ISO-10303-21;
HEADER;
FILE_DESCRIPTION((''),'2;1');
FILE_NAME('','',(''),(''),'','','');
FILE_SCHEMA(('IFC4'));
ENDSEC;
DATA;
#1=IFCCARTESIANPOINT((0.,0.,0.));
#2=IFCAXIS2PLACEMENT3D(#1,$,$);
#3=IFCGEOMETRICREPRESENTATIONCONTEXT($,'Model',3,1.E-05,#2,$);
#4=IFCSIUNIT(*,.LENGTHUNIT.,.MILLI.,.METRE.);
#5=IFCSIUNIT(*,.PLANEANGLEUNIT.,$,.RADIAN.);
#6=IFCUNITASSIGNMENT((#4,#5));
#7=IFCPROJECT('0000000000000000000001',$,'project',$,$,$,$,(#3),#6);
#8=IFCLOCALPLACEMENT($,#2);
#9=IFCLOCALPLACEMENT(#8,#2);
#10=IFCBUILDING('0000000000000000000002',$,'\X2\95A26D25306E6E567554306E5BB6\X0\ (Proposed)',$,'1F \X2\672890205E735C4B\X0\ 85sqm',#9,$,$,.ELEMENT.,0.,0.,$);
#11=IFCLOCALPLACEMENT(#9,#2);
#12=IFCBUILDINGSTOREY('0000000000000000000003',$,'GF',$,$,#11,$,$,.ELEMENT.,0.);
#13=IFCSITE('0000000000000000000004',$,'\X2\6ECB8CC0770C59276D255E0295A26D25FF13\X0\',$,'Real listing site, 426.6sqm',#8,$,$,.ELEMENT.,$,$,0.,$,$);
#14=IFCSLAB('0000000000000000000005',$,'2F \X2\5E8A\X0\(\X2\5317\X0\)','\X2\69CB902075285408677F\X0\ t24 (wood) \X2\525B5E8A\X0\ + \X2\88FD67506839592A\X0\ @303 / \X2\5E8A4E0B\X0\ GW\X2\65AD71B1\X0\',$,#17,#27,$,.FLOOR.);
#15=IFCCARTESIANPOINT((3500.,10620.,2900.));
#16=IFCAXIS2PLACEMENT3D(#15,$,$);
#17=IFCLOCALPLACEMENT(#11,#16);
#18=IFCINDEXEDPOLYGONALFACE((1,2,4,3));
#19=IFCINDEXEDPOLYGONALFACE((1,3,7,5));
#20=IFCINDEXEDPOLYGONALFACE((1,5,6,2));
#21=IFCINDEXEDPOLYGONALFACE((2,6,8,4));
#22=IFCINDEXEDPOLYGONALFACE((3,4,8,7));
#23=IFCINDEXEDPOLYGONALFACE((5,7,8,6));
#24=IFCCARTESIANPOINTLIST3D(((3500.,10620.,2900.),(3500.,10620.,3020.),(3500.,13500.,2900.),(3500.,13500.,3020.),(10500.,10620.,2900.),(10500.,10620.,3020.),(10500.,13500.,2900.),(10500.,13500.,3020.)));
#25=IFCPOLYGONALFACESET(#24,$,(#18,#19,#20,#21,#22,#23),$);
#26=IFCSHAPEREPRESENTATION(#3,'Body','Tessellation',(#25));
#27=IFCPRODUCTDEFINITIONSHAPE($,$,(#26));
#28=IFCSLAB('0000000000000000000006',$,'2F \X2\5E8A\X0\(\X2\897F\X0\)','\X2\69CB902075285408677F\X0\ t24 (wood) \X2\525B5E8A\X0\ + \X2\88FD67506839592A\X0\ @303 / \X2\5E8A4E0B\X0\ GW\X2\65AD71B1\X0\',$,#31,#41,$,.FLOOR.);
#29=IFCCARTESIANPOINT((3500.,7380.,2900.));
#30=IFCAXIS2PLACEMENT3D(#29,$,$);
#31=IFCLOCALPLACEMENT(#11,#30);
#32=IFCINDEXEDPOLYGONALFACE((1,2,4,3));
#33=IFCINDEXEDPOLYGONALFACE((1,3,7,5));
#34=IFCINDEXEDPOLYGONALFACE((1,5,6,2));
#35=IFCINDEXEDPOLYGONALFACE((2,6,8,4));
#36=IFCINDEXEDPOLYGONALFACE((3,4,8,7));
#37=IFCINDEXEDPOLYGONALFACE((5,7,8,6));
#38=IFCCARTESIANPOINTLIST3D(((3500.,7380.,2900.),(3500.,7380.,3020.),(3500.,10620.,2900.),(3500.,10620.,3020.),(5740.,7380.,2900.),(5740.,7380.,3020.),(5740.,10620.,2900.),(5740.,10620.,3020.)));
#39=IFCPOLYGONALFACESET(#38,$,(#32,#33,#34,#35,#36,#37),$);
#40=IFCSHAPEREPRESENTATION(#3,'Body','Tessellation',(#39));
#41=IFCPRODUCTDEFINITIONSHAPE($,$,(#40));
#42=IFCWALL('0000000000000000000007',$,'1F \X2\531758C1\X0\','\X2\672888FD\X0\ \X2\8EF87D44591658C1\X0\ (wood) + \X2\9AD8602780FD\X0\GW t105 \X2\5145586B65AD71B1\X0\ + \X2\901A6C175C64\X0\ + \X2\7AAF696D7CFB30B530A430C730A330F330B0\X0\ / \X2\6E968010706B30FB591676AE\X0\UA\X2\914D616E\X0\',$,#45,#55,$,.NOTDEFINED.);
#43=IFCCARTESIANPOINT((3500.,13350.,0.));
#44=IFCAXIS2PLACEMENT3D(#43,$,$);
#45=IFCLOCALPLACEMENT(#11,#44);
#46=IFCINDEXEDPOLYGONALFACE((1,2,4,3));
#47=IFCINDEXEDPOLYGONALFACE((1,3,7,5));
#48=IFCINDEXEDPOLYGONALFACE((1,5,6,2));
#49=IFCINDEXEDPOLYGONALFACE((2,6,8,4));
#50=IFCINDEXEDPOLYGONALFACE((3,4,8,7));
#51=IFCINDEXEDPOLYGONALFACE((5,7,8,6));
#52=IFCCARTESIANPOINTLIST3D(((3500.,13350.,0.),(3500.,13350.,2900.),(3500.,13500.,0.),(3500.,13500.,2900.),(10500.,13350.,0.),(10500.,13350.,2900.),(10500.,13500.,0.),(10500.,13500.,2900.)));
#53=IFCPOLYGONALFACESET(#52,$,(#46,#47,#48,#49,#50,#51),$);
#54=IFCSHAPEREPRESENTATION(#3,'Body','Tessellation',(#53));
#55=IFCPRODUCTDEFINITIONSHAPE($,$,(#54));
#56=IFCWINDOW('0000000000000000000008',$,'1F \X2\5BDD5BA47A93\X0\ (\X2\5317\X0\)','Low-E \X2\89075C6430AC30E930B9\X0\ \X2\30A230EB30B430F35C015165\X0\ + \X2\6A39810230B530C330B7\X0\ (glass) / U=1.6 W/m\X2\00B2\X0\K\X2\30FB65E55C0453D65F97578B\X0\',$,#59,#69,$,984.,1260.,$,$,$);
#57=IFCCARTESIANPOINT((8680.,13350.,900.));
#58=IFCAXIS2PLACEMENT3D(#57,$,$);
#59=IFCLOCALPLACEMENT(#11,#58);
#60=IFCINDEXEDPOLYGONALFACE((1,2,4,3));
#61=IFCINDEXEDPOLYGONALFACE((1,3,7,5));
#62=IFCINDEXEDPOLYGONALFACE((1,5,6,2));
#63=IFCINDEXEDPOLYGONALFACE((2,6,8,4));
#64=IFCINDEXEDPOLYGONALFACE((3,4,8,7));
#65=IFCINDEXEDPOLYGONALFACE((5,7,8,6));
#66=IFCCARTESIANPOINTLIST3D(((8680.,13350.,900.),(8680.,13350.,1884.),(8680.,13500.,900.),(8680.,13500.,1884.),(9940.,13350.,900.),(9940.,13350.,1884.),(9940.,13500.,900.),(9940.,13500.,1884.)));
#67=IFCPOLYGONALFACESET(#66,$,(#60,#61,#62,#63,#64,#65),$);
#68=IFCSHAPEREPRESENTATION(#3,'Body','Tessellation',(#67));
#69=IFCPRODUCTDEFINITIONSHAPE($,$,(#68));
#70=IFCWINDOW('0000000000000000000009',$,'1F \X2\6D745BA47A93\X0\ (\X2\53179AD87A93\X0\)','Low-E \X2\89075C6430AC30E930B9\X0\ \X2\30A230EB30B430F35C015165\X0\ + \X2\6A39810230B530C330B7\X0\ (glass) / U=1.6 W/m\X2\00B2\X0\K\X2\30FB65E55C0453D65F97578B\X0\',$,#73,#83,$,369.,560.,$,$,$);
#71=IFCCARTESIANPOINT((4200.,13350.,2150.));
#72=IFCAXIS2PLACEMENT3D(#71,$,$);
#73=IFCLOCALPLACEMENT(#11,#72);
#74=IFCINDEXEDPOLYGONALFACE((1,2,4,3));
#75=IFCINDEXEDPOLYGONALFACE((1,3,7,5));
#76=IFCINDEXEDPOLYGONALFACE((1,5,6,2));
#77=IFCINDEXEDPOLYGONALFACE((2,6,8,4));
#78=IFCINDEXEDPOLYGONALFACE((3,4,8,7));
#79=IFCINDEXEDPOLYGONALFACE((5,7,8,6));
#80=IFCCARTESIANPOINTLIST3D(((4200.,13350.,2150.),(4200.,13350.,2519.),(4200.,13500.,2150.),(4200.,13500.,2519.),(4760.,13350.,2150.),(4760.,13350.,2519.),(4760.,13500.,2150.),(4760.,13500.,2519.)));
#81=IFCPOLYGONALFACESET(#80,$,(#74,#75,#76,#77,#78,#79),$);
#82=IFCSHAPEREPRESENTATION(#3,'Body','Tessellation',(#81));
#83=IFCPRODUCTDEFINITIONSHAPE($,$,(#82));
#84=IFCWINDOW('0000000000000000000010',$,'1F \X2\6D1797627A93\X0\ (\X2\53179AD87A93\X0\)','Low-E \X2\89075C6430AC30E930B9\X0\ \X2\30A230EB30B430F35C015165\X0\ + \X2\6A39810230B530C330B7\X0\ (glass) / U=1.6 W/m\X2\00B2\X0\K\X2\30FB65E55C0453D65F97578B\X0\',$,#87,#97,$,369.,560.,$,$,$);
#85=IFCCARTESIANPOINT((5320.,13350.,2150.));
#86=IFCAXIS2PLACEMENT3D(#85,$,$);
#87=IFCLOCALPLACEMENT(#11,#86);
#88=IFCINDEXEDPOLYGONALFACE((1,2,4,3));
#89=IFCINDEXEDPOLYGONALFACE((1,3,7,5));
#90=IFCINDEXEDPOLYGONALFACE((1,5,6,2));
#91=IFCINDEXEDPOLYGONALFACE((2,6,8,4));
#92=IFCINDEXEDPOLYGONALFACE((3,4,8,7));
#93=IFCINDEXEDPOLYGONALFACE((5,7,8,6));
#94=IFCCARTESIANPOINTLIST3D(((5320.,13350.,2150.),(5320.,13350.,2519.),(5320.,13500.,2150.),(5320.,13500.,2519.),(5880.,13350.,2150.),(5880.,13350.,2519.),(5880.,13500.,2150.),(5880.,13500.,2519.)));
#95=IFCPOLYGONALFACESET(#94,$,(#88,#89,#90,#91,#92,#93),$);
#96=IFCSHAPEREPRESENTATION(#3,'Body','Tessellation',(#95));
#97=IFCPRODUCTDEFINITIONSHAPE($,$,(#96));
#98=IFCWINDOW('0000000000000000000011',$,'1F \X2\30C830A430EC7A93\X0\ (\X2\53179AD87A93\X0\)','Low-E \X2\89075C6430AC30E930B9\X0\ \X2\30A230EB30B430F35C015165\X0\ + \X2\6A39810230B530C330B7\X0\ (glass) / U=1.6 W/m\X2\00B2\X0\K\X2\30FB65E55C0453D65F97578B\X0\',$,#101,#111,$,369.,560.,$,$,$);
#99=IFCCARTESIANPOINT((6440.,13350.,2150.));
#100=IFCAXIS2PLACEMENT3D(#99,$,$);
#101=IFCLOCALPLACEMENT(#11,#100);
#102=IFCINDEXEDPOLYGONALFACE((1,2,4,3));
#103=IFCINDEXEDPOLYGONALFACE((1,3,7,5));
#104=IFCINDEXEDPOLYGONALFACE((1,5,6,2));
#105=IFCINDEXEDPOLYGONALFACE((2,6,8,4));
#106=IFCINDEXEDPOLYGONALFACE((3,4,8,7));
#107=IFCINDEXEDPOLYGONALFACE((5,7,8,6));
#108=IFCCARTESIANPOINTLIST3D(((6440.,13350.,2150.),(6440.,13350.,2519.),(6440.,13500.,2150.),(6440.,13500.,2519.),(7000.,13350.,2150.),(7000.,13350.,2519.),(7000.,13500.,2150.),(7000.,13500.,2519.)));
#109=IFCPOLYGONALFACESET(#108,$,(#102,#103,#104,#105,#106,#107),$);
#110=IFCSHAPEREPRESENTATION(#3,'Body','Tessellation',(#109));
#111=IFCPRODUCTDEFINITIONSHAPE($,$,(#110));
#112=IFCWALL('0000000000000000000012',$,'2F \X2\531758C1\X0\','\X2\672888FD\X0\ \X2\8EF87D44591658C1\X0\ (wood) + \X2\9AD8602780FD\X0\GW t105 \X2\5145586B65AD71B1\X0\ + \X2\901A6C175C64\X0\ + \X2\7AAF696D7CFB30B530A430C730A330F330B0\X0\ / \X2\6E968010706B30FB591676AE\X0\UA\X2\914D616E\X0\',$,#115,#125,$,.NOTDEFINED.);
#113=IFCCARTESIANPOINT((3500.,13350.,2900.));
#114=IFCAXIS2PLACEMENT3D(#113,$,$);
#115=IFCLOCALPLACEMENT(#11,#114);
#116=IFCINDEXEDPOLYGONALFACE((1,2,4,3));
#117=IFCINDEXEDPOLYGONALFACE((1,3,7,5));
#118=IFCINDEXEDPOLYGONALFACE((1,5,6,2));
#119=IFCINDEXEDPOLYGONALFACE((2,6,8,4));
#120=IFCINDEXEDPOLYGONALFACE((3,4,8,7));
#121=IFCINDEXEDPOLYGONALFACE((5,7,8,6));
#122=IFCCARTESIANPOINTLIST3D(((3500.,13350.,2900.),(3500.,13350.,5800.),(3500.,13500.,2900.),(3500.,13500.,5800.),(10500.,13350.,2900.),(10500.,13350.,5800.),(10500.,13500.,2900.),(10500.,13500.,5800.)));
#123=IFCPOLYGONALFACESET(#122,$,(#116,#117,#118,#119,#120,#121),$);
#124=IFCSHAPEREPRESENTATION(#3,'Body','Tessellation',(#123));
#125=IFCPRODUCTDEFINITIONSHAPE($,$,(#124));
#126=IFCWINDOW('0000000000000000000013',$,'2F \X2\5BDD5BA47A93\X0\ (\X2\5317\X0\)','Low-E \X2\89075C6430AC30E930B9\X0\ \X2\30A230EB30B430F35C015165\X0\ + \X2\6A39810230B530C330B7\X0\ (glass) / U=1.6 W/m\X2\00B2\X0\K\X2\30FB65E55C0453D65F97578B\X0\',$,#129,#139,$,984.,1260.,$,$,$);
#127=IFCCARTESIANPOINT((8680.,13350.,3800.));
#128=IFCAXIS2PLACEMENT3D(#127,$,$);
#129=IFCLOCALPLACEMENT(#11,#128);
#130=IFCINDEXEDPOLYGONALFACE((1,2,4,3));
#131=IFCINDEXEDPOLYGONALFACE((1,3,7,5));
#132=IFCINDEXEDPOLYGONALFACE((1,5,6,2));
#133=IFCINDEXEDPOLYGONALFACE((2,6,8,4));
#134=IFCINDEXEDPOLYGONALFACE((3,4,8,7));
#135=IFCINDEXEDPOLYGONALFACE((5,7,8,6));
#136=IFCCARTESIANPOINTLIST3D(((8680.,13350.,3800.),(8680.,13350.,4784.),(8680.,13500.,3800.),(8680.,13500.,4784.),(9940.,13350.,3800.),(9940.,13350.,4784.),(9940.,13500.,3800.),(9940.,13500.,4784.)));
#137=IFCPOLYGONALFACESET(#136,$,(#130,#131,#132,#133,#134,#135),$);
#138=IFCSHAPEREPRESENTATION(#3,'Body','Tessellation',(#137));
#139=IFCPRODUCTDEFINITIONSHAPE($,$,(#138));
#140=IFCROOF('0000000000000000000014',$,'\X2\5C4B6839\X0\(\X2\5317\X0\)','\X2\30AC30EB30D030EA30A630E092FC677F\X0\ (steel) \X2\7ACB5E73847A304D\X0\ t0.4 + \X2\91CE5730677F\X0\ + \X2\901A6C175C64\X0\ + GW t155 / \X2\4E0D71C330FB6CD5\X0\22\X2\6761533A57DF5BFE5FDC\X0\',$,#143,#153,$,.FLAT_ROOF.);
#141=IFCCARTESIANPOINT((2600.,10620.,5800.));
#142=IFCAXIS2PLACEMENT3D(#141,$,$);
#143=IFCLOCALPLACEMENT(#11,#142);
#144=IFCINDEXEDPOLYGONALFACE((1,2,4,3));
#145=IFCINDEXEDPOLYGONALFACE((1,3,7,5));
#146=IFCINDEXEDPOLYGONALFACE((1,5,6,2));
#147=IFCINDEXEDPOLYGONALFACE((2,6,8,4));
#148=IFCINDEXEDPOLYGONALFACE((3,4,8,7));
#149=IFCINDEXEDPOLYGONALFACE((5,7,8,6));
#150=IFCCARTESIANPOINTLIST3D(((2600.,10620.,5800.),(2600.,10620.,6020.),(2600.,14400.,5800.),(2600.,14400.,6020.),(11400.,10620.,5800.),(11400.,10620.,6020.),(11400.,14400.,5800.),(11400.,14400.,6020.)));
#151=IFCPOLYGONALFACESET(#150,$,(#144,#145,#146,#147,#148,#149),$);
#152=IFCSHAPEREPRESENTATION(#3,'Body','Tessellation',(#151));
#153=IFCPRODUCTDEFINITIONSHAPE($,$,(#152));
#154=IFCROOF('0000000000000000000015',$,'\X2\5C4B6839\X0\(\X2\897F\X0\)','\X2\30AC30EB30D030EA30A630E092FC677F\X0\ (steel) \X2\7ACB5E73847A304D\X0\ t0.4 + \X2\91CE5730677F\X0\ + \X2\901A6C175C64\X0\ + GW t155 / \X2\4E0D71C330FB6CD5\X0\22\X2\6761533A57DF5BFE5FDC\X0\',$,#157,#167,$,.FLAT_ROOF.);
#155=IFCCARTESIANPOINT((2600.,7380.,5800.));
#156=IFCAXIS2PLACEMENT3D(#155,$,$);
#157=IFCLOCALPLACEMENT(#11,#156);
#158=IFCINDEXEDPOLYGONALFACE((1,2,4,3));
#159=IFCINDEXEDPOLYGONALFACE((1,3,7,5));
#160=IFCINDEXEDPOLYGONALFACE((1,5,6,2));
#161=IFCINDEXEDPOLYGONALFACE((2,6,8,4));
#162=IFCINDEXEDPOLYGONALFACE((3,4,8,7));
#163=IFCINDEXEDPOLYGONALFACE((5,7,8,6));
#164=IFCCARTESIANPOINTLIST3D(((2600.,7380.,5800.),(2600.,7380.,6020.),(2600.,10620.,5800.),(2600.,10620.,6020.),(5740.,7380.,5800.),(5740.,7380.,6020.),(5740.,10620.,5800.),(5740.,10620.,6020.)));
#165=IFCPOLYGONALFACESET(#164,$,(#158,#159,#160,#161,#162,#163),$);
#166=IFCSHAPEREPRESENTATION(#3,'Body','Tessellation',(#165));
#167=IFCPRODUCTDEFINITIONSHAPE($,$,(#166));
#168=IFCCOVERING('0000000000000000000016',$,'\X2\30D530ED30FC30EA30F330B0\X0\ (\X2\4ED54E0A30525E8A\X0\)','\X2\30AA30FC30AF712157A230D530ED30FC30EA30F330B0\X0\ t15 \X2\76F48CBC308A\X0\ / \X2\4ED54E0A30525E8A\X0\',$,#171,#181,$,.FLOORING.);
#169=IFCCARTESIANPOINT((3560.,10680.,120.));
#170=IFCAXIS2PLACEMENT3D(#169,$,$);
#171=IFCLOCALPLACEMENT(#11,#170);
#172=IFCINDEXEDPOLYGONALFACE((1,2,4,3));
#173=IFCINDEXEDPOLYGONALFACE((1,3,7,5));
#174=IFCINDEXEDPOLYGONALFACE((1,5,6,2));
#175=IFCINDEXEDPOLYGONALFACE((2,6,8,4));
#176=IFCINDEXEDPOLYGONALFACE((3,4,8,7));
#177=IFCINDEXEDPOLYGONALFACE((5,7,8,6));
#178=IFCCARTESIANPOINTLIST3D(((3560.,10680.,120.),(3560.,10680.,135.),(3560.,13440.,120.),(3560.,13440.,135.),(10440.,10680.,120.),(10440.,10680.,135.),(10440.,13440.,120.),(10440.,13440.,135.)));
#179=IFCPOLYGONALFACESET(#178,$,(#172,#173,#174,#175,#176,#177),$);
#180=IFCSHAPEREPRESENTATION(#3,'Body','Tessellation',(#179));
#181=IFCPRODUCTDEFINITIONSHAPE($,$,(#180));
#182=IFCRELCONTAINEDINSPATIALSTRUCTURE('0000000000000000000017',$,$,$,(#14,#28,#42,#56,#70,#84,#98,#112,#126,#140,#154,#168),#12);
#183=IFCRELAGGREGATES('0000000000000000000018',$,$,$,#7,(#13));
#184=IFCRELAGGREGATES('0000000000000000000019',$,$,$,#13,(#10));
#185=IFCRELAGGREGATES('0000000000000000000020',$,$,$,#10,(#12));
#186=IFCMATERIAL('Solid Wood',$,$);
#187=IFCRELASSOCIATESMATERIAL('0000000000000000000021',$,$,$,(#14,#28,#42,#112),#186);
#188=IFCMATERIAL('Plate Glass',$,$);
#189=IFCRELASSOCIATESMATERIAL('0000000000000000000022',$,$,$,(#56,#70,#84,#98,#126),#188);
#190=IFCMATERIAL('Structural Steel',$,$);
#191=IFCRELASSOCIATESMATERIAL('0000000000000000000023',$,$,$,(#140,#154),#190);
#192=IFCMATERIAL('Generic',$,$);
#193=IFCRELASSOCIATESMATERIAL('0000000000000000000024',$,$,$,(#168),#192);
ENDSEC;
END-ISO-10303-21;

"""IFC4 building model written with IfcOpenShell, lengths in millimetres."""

from ifc_helpers import new_model, si_unit, frame, frame_2d, origin, place, context, project, spatial, rectangle, extrude, material, element, fill, save


model = new_model("IFC4")

# Units and contexts
model_context = context("Model", 3, precision=1e-05, world=origin())
ifc_project = project(units=[si_unit("LENGTHUNIT", "METRE", prefix="MILLI"), si_unit("PLANEANGLEUNIT", "RADIAN")], contexts=[model_context])

# Site, building, storey
site_placement = place(None, origin())
site = spatial("IfcSite", under=ifc_project, at=site_placement, Name="滋賀県大津市関津３", ObjectType="Real listing site, 426.6sqm", CompositionType="ELEMENT", RefElevation=0.0)
building_placement = place(site_placement, origin())
building = spatial("IfcBuilding", under=site, at=building_placement, Name="関津の湖畔の家 (Proposed)", ObjectType="1F 木造平屋 85sqm", CompositionType="ELEMENT", ElevationOfRefHeight=0.0, ElevationOfTerrain=0.0)
storey_placement = place(building_placement, origin())
storey = spatial("IfcBuildingStorey", under=building, at=storey_placement, Name="GF", CompositionType="ELEMENT", Elevation=0.0)

# Slabs
ifc_material_1 = material(Name="Solid Wood")
slab_1_placement = place(storey_placement, frame((3500.0, 10620.0, 2900.0)))
element("IfcSlab", 1, at=slab_1_placement, inside=storey, material=ifc_material_1, Name="2F 床(北)", Description="構造用合板 t24 (wood) 剛床 + 製材根太 @303 / 床下 GW断熱", PredefinedType="FLOOR", context=model_context, shape_type="SweptSolid", body=[
    extrude(rectangle(XDim=7000.0, YDim=2880.0, at=frame_2d((3500.0, 1440.0))), frame((3500.0, 10620.0, 2900.0)), (0.0, 0.0, 1.0), 120.0),
])
slab_2_placement = place(storey_placement, frame((3500.0, 7380.0, 2900.0)))
element("IfcSlab", 2, at=slab_2_placement, inside=storey, material=ifc_material_1, Name="2F 床(西)", Description="構造用合板 t24 (wood) 剛床 + 製材根太 @303 / 床下 GW断熱", PredefinedType="FLOOR", context=model_context, shape_type="SweptSolid", body=[
    extrude(rectangle(XDim=2240.0, YDim=3240.0, at=frame_2d((1120.0, 1620.0))), frame((3500.0, 7380.0, 2900.0)), (0.0, 0.0, 1.0), 120.0),
])

# Wall, openings, windows
wall_1_placement = place(storey_placement, frame((3500.0, 13350.0, 0.0)))
wall_1 = element("IfcWall", 3, at=wall_1_placement, inside=storey, material=ifc_material_1, Name="1F 北壁", Description="木製 軸組外壁 (wood) + 高性能GW t105 充填断熱 + 通気層 + 窯業系サイディング / 準耐火・外皮UA配慮", PredefinedType="NOTDEFINED", context=model_context, shape_type="SweptSolid", body=[
    extrude(rectangle(XDim=7000.0, YDim=150.0, at=frame_2d((3500.0, 75.0))), frame((3500.0, 13350.0, 0.0)), (0.0, 0.0, 1.0), 2900.0),
])
opening_1_placement = place(storey_placement, frame((8680.0, 13350.0, 900.0)))
opening_1 = element("IfcOpeningElement", 4, at=opening_1_placement, cuts=wall_1, PredefinedType="NOTDEFINED", context=model_context, shape_type="SweptSolid", body=[
    extrude(rectangle(XDim=1260.0, YDim=150.0, at=frame_2d((630.0, 75.0))), frame((8680.0, 13350.0, 900.0)), (0.0, 0.0, 1.0), 984.0),
])
opening_2_placement = place(storey_placement, frame((4200.0, 13350.0, 2150.0)))
opening_2 = element("IfcOpeningElement", 5, at=opening_2_placement, cuts=wall_1, PredefinedType="NOTDEFINED", context=model_context, shape_type="SweptSolid", body=[
    extrude(rectangle(XDim=560.0, YDim=150.0, at=frame_2d((280.0, 75.0))), frame((4200.0, 13350.0, 2150.0)), (0.0, 0.0, 1.0), 369.0),
])
opening_3_placement = place(storey_placement, frame((5320.0, 13350.0, 2150.0)))
opening_3 = element("IfcOpeningElement", 6, at=opening_3_placement, cuts=wall_1, PredefinedType="NOTDEFINED", context=model_context, shape_type="SweptSolid", body=[
    extrude(rectangle(XDim=560.0, YDim=150.0, at=frame_2d((280.0, 75.0))), frame((5320.0, 13350.0, 2150.0)), (0.0, 0.0, 1.0), 369.0),
])
opening_4_placement = place(storey_placement, frame((6440.0, 13350.0, 2150.0)))
opening_4 = element("IfcOpeningElement", 7, at=opening_4_placement, cuts=wall_1, PredefinedType="NOTDEFINED", context=model_context, shape_type="SweptSolid", body=[
    extrude(rectangle(XDim=560.0, YDim=150.0, at=frame_2d((280.0, 75.0))), frame((6440.0, 13350.0, 2150.0)), (0.0, 0.0, 1.0), 369.0),
])
ifc_material_2 = material(Name="Plate Glass")
window_1_placement = place(storey_placement, frame((8680.0, 13350.0, 900.0)))
window_1 = element("IfcWindow", 8, at=window_1_placement, inside=storey, material=ifc_material_2, Name="1F 寝室窓 (北)", Description="Low-E 複層ガラス アルゴン封入 + 樹脂サッシ (glass) / U=1.6 W/m²K・日射取得型", OverallHeight=984.0, OverallWidth=1260.0, context=model_context, shape_type="SweptSolid", body=[
    extrude(rectangle(XDim=1260.0, YDim=150.0, at=frame_2d((630.0, 75.0))), frame((8680.0, 13350.0, 900.0)), (0.0, 0.0, 1.0), 984.0),
])
fill(opening_1, window_1)
window_2_placement = place(storey_placement, frame((4200.0, 13350.0, 2150.0)))
window_2 = element("IfcWindow", 9, at=window_2_placement, inside=storey, material=ifc_material_2, Name="1F 浴室窓 (北高窓)", Description="Low-E 複層ガラス アルゴン封入 + 樹脂サッシ (glass) / U=1.6 W/m²K・日射取得型", OverallHeight=369.0, OverallWidth=560.0, context=model_context, shape_type="SweptSolid", body=[
    extrude(rectangle(XDim=560.0, YDim=150.0, at=frame_2d((280.0, 75.0))), frame((4200.0, 13350.0, 2150.0)), (0.0, 0.0, 1.0), 369.0),
])
fill(opening_2, window_2)
window_3_placement = place(storey_placement, frame((5320.0, 13350.0, 2150.0)))
window_3 = element("IfcWindow", 10, at=window_3_placement, inside=storey, material=ifc_material_2, Name="1F 洗面窓 (北高窓)", Description="Low-E 複層ガラス アルゴン封入 + 樹脂サッシ (glass) / U=1.6 W/m²K・日射取得型", OverallHeight=369.0, OverallWidth=560.0, context=model_context, shape_type="SweptSolid", body=[
    extrude(rectangle(XDim=560.0, YDim=150.0, at=frame_2d((280.0, 75.0))), frame((5320.0, 13350.0, 2150.0)), (0.0, 0.0, 1.0), 369.0),
])
fill(opening_3, window_3)
window_4_placement = place(storey_placement, frame((6440.0, 13350.0, 2150.0)))
window_4 = element("IfcWindow", 11, at=window_4_placement, inside=storey, material=ifc_material_2, Name="1F トイレ窓 (北高窓)", Description="Low-E 複層ガラス アルゴン封入 + 樹脂サッシ (glass) / U=1.6 W/m²K・日射取得型", OverallHeight=369.0, OverallWidth=560.0, context=model_context, shape_type="SweptSolid", body=[
    extrude(rectangle(XDim=560.0, YDim=150.0, at=frame_2d((280.0, 75.0))), frame((6440.0, 13350.0, 2150.0)), (0.0, 0.0, 1.0), 369.0),
])
fill(opening_4, window_4)

# Wall, opening, window
wall_2_placement = place(storey_placement, frame((3500.0, 13350.0, 2900.0)))
wall_2 = element("IfcWall", 12, at=wall_2_placement, inside=storey, material=ifc_material_1, Name="2F 北壁", Description="木製 軸組外壁 (wood) + 高性能GW t105 充填断熱 + 通気層 + 窯業系サイディング / 準耐火・外皮UA配慮", PredefinedType="NOTDEFINED", context=model_context, shape_type="SweptSolid", body=[
    extrude(rectangle(XDim=7000.0, YDim=150.0, at=frame_2d((3500.0, 75.0))), frame((3500.0, 13350.0, 2900.0)), (0.0, 0.0, 1.0), 2900.0),
])
opening_5_placement = place(storey_placement, frame((8680.0, 13350.0, 3800.0)))
opening_5 = element("IfcOpeningElement", 13, at=opening_5_placement, cuts=wall_2, PredefinedType="NOTDEFINED", context=model_context, shape_type="SweptSolid", body=[
    extrude(rectangle(XDim=1260.0, YDim=150.0, at=frame_2d((630.0, 75.0))), frame((8680.0, 13350.0, 3800.0)), (0.0, 0.0, 1.0), 984.0),
])
window_5_placement = place(storey_placement, frame((8680.0, 13350.0, 3800.0)))
window_5 = element("IfcWindow", 14, at=window_5_placement, inside=storey, material=ifc_material_2, Name="2F 寝室窓 (北)", Description="Low-E 複層ガラス アルゴン封入 + 樹脂サッシ (glass) / U=1.6 W/m²K・日射取得型", OverallHeight=984.0, OverallWidth=1260.0, context=model_context, shape_type="SweptSolid", body=[
    extrude(rectangle(XDim=1260.0, YDim=150.0, at=frame_2d((630.0, 75.0))), frame((8680.0, 13350.0, 3800.0)), (0.0, 0.0, 1.0), 984.0),
])
fill(opening_5, window_5)

# Roofs
ifc_material_3 = material(Name="Structural Steel")
for number, where, name in (
    (15, (2600.0, 10620.0, 5800.0), "屋根(北)"),
):
    element("IfcRoof", number, at=place(storey_placement, frame(where)), inside=storey, material=ifc_material_3, Name=name, Description="ガルバリウム鋼板 (steel) 立平葺き t0.4 + 野地板 + 通気層 + GW t155 / 不燃・法22条区域対応", PredefinedType="FLAT_ROOF", context=model_context, shape_type="SweptSolid", body=[
        extrude(rectangle(XDim=8800.0, YDim=3780.0, at=frame_2d((4400.0, 1890.0))), frame((2600.0, 10620.0, 5800.0)), (0.0, 0.0, 1.0), 220.0),
    ])
roof_placement = place(storey_placement, frame((2600.0, 7380.0, 5800.0)))
element("IfcRoof", 16, at=roof_placement, inside=storey, material=ifc_material_3, Name="屋根(西)", Description="ガルバリウム鋼板 (steel) 立平葺き t0.4 + 野地板 + 通気層 + GW t155 / 不燃・法22条区域対応", PredefinedType="FLAT_ROOF", context=model_context, shape_type="SweptSolid", body=[
    extrude(rectangle(XDim=3140.0, YDim=3240.0, at=frame_2d((1570.0, 1620.0))), frame((2600.0, 7380.0, 5800.0)), (0.0, 0.0, 1.0), 220.0),
])

# Covering
ifc_material_4 = material(Name="Generic")
covering_1_placement = place(storey_placement, frame((3560.0, 10680.0, 120.0)))
element("IfcCovering", 17, at=covering_1_placement, inside=storey, material=ifc_material_4, Name="フローリング (仕上げ床)", Description="オーク無垢フローリング t15 直貼り / 仕上げ床", PredefinedType="FLOORING", context=model_context, shape_type="SweptSolid", body=[
    extrude(rectangle(XDim=6880.0, YDim=2760.0, at=frame_2d((3440.0, 1380.0))), frame((3560.0, 10680.0, 120.0)), (0.0, 0.0, 1.0), 15.0),
])

save(model, "model.ifc")
